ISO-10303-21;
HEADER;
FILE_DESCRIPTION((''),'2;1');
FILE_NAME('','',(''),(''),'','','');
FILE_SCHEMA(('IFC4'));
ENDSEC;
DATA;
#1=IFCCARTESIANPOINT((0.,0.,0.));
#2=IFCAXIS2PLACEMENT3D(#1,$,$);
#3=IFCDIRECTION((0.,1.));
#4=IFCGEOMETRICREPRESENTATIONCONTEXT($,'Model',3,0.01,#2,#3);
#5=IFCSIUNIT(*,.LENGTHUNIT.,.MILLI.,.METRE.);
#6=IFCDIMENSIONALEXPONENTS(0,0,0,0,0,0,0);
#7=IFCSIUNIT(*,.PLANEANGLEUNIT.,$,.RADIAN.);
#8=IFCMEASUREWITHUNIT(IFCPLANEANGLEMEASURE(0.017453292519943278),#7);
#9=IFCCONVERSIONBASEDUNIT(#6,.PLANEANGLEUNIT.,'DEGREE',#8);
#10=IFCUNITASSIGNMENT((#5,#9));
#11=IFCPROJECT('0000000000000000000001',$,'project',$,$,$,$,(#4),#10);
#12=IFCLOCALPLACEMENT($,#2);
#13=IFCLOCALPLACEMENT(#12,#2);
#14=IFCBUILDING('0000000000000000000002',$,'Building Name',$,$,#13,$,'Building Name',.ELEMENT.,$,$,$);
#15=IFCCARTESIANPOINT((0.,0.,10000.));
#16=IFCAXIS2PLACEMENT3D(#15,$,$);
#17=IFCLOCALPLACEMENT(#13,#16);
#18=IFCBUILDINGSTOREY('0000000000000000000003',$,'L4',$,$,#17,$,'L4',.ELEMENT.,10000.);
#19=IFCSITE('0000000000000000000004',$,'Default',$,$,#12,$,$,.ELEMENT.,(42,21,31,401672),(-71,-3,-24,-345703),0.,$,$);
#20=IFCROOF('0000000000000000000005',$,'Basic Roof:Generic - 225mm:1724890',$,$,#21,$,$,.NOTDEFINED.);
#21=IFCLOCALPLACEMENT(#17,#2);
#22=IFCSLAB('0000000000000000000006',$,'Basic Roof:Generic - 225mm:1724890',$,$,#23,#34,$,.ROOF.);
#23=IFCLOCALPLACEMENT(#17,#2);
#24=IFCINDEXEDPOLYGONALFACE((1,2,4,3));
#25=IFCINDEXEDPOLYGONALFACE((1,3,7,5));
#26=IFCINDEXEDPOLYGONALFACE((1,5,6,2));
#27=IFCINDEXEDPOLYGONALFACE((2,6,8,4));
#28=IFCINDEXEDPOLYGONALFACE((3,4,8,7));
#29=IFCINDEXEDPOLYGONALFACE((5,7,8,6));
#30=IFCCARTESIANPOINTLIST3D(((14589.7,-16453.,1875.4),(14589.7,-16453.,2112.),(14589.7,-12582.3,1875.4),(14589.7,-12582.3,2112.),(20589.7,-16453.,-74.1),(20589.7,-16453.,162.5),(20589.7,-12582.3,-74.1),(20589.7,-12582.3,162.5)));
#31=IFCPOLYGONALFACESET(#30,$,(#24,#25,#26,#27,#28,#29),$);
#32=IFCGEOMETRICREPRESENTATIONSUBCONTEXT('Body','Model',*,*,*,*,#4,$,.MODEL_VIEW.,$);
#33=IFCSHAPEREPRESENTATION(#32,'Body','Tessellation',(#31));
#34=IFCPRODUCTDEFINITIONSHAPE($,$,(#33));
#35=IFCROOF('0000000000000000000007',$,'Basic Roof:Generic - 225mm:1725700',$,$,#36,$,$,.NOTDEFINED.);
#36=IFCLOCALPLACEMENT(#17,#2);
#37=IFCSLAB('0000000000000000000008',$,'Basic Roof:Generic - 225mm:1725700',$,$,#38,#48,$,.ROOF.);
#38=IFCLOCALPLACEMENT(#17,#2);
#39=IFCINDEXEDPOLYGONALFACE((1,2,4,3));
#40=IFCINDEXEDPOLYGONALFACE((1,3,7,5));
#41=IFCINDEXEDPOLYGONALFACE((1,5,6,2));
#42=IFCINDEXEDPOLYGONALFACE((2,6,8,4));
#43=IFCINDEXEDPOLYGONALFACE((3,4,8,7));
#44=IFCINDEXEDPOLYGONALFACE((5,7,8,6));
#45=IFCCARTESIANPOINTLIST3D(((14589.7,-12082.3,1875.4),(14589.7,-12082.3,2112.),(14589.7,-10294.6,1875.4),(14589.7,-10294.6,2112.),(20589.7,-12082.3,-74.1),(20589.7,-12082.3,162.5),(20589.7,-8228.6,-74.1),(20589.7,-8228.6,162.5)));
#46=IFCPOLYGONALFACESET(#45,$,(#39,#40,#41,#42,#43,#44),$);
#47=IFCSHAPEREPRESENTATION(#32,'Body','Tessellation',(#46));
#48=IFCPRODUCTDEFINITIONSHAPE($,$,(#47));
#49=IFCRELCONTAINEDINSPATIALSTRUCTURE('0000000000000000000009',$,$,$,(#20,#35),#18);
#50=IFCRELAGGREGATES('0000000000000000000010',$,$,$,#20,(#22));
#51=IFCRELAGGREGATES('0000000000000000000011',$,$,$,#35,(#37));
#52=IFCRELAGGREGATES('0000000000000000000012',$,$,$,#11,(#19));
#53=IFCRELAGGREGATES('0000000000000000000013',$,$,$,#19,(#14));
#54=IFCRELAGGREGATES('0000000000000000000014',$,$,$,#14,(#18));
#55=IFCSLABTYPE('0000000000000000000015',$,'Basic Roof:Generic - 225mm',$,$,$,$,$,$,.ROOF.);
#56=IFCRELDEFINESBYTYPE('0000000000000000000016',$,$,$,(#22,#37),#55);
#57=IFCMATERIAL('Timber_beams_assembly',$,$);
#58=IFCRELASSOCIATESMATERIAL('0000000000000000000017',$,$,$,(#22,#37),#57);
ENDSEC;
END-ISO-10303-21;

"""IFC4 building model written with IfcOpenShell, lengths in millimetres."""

from ifc_helpers import new_model, entity, si_unit, converted_unit, direction, frame, origin, place, context, subcontext, project, spatial, indexed_curve, outline, extrude, material, type_object, element, aggregate, save


model = new_model("IFC4")

# Units and contexts
model_context = context("Model", 3, precision=0.01, world=origin(), true_north=direction((0.0, 1.0)))
body_context = subcontext(model_context, "Body", "Model", "MODEL_VIEW")
ifc_project = project(units=[si_unit("LENGTHUNIT", "METRE", prefix="MILLI"), converted_unit("PLANEANGLEUNIT", "DEGREE", entity("IfcPlaneAngleMeasure", 0.017453292519943278), si_unit("PLANEANGLEUNIT", "RADIAN"), dimensions=[0, 0, 0, 0, 0, 0, 0])], contexts=[model_context])

# Site, building, storey
site_placement = place(None, origin())
site = spatial("IfcSite", under=ifc_project, at=site_placement, Name="Default", CompositionType="ELEMENT", RefLatitude=(42, 21, 31, 401672), RefLongitude=(-71, -3, -24, -345703), RefElevation=0.0)
building_placement = place(site_placement, origin())
building = spatial("IfcBuilding", under=site, at=building_placement, Name="Building Name", LongName="Building Name", CompositionType="ELEMENT")
storey_placement = place(building_placement, frame((0.0, 0.0, 10000.0)))
storey = spatial("IfcBuildingStorey", under=building, at=storey_placement, Name="L4", LongName="L4", CompositionType="ELEMENT", Elevation=10000.0)

# Shared definitions
ifc_material = material(Name="Timber_beams_assembly")
slab_type = type_object("IfcSlabType", Name="Basic Roof:Generic - 225mm", PredefinedType="ROOF")

# Roofs, slabs
roof_1_placement = place(storey_placement, frame((14589.7, -16453.0, -74.1)))
roof_1 = element("IfcRoof", 1, at=roof_1_placement, inside=storey, Name="Basic Roof:Generic - 225mm:1724890", PredefinedType="NOTDEFINED")
slab_1_placement = place(roof_1_placement, origin())
slab_1 = element("IfcSlab", 2, at=slab_1_placement, type_object=slab_type, material=ifc_material, Name="Basic Roof:Generic - 225mm:1724890", PredefinedType="ROOF", context=body_context, shape_type="SweptSolid", body=[
    extrude(outline(indexed_curve([(-3154.4, -1935.3), (3154.4, -1935.3), (3154.4, 1935.3), (-3154.4, 1935.3), (-3154.4, -1935.3)], self_intersect=False)), frame((3000.0, 1935.3, 974.8), z_axis=(0.309017, 0.0, 0.951057), x_axis=(0.951057, 0.0, -0.309017)), (-0.309017, 0.0, 0.951057), 236.6),
])
aggregate(roof_1, [slab_1])
roof_2_placement = place(storey_placement, frame((14589.7, -12082.3, -74.1)))
roof_2 = element("IfcRoof", 3, at=roof_2_placement, inside=storey, Name="Basic Roof:Generic - 225mm:1725700", PredefinedType="NOTDEFINED")
slab_2_placement = place(roof_2_placement, origin())
slab_2 = element("IfcSlab", 4, at=slab_2_placement, type_object=slab_type, material=ifc_material, Name="Basic Roof:Generic - 225mm:1725700", PredefinedType="ROOF", context=body_context, shape_type="SweptSolid", body=[
    extrude(outline(indexed_curve([(-3154.4, -139.1), (-3154.4, -1926.9), (3154.4, -1926.9), (3154.4, 1926.9), (-3154.4, -139.1)], self_intersect=False)), frame((3000.0, 1926.9, 974.8), z_axis=(0.309017, 0.0, 0.951057), x_axis=(0.951057, 0.0, -0.309017)), (-0.309017, 0.0, 0.951057), 236.6),
])
aggregate(roof_2, [slab_2])

save(model, "model.ifc")
